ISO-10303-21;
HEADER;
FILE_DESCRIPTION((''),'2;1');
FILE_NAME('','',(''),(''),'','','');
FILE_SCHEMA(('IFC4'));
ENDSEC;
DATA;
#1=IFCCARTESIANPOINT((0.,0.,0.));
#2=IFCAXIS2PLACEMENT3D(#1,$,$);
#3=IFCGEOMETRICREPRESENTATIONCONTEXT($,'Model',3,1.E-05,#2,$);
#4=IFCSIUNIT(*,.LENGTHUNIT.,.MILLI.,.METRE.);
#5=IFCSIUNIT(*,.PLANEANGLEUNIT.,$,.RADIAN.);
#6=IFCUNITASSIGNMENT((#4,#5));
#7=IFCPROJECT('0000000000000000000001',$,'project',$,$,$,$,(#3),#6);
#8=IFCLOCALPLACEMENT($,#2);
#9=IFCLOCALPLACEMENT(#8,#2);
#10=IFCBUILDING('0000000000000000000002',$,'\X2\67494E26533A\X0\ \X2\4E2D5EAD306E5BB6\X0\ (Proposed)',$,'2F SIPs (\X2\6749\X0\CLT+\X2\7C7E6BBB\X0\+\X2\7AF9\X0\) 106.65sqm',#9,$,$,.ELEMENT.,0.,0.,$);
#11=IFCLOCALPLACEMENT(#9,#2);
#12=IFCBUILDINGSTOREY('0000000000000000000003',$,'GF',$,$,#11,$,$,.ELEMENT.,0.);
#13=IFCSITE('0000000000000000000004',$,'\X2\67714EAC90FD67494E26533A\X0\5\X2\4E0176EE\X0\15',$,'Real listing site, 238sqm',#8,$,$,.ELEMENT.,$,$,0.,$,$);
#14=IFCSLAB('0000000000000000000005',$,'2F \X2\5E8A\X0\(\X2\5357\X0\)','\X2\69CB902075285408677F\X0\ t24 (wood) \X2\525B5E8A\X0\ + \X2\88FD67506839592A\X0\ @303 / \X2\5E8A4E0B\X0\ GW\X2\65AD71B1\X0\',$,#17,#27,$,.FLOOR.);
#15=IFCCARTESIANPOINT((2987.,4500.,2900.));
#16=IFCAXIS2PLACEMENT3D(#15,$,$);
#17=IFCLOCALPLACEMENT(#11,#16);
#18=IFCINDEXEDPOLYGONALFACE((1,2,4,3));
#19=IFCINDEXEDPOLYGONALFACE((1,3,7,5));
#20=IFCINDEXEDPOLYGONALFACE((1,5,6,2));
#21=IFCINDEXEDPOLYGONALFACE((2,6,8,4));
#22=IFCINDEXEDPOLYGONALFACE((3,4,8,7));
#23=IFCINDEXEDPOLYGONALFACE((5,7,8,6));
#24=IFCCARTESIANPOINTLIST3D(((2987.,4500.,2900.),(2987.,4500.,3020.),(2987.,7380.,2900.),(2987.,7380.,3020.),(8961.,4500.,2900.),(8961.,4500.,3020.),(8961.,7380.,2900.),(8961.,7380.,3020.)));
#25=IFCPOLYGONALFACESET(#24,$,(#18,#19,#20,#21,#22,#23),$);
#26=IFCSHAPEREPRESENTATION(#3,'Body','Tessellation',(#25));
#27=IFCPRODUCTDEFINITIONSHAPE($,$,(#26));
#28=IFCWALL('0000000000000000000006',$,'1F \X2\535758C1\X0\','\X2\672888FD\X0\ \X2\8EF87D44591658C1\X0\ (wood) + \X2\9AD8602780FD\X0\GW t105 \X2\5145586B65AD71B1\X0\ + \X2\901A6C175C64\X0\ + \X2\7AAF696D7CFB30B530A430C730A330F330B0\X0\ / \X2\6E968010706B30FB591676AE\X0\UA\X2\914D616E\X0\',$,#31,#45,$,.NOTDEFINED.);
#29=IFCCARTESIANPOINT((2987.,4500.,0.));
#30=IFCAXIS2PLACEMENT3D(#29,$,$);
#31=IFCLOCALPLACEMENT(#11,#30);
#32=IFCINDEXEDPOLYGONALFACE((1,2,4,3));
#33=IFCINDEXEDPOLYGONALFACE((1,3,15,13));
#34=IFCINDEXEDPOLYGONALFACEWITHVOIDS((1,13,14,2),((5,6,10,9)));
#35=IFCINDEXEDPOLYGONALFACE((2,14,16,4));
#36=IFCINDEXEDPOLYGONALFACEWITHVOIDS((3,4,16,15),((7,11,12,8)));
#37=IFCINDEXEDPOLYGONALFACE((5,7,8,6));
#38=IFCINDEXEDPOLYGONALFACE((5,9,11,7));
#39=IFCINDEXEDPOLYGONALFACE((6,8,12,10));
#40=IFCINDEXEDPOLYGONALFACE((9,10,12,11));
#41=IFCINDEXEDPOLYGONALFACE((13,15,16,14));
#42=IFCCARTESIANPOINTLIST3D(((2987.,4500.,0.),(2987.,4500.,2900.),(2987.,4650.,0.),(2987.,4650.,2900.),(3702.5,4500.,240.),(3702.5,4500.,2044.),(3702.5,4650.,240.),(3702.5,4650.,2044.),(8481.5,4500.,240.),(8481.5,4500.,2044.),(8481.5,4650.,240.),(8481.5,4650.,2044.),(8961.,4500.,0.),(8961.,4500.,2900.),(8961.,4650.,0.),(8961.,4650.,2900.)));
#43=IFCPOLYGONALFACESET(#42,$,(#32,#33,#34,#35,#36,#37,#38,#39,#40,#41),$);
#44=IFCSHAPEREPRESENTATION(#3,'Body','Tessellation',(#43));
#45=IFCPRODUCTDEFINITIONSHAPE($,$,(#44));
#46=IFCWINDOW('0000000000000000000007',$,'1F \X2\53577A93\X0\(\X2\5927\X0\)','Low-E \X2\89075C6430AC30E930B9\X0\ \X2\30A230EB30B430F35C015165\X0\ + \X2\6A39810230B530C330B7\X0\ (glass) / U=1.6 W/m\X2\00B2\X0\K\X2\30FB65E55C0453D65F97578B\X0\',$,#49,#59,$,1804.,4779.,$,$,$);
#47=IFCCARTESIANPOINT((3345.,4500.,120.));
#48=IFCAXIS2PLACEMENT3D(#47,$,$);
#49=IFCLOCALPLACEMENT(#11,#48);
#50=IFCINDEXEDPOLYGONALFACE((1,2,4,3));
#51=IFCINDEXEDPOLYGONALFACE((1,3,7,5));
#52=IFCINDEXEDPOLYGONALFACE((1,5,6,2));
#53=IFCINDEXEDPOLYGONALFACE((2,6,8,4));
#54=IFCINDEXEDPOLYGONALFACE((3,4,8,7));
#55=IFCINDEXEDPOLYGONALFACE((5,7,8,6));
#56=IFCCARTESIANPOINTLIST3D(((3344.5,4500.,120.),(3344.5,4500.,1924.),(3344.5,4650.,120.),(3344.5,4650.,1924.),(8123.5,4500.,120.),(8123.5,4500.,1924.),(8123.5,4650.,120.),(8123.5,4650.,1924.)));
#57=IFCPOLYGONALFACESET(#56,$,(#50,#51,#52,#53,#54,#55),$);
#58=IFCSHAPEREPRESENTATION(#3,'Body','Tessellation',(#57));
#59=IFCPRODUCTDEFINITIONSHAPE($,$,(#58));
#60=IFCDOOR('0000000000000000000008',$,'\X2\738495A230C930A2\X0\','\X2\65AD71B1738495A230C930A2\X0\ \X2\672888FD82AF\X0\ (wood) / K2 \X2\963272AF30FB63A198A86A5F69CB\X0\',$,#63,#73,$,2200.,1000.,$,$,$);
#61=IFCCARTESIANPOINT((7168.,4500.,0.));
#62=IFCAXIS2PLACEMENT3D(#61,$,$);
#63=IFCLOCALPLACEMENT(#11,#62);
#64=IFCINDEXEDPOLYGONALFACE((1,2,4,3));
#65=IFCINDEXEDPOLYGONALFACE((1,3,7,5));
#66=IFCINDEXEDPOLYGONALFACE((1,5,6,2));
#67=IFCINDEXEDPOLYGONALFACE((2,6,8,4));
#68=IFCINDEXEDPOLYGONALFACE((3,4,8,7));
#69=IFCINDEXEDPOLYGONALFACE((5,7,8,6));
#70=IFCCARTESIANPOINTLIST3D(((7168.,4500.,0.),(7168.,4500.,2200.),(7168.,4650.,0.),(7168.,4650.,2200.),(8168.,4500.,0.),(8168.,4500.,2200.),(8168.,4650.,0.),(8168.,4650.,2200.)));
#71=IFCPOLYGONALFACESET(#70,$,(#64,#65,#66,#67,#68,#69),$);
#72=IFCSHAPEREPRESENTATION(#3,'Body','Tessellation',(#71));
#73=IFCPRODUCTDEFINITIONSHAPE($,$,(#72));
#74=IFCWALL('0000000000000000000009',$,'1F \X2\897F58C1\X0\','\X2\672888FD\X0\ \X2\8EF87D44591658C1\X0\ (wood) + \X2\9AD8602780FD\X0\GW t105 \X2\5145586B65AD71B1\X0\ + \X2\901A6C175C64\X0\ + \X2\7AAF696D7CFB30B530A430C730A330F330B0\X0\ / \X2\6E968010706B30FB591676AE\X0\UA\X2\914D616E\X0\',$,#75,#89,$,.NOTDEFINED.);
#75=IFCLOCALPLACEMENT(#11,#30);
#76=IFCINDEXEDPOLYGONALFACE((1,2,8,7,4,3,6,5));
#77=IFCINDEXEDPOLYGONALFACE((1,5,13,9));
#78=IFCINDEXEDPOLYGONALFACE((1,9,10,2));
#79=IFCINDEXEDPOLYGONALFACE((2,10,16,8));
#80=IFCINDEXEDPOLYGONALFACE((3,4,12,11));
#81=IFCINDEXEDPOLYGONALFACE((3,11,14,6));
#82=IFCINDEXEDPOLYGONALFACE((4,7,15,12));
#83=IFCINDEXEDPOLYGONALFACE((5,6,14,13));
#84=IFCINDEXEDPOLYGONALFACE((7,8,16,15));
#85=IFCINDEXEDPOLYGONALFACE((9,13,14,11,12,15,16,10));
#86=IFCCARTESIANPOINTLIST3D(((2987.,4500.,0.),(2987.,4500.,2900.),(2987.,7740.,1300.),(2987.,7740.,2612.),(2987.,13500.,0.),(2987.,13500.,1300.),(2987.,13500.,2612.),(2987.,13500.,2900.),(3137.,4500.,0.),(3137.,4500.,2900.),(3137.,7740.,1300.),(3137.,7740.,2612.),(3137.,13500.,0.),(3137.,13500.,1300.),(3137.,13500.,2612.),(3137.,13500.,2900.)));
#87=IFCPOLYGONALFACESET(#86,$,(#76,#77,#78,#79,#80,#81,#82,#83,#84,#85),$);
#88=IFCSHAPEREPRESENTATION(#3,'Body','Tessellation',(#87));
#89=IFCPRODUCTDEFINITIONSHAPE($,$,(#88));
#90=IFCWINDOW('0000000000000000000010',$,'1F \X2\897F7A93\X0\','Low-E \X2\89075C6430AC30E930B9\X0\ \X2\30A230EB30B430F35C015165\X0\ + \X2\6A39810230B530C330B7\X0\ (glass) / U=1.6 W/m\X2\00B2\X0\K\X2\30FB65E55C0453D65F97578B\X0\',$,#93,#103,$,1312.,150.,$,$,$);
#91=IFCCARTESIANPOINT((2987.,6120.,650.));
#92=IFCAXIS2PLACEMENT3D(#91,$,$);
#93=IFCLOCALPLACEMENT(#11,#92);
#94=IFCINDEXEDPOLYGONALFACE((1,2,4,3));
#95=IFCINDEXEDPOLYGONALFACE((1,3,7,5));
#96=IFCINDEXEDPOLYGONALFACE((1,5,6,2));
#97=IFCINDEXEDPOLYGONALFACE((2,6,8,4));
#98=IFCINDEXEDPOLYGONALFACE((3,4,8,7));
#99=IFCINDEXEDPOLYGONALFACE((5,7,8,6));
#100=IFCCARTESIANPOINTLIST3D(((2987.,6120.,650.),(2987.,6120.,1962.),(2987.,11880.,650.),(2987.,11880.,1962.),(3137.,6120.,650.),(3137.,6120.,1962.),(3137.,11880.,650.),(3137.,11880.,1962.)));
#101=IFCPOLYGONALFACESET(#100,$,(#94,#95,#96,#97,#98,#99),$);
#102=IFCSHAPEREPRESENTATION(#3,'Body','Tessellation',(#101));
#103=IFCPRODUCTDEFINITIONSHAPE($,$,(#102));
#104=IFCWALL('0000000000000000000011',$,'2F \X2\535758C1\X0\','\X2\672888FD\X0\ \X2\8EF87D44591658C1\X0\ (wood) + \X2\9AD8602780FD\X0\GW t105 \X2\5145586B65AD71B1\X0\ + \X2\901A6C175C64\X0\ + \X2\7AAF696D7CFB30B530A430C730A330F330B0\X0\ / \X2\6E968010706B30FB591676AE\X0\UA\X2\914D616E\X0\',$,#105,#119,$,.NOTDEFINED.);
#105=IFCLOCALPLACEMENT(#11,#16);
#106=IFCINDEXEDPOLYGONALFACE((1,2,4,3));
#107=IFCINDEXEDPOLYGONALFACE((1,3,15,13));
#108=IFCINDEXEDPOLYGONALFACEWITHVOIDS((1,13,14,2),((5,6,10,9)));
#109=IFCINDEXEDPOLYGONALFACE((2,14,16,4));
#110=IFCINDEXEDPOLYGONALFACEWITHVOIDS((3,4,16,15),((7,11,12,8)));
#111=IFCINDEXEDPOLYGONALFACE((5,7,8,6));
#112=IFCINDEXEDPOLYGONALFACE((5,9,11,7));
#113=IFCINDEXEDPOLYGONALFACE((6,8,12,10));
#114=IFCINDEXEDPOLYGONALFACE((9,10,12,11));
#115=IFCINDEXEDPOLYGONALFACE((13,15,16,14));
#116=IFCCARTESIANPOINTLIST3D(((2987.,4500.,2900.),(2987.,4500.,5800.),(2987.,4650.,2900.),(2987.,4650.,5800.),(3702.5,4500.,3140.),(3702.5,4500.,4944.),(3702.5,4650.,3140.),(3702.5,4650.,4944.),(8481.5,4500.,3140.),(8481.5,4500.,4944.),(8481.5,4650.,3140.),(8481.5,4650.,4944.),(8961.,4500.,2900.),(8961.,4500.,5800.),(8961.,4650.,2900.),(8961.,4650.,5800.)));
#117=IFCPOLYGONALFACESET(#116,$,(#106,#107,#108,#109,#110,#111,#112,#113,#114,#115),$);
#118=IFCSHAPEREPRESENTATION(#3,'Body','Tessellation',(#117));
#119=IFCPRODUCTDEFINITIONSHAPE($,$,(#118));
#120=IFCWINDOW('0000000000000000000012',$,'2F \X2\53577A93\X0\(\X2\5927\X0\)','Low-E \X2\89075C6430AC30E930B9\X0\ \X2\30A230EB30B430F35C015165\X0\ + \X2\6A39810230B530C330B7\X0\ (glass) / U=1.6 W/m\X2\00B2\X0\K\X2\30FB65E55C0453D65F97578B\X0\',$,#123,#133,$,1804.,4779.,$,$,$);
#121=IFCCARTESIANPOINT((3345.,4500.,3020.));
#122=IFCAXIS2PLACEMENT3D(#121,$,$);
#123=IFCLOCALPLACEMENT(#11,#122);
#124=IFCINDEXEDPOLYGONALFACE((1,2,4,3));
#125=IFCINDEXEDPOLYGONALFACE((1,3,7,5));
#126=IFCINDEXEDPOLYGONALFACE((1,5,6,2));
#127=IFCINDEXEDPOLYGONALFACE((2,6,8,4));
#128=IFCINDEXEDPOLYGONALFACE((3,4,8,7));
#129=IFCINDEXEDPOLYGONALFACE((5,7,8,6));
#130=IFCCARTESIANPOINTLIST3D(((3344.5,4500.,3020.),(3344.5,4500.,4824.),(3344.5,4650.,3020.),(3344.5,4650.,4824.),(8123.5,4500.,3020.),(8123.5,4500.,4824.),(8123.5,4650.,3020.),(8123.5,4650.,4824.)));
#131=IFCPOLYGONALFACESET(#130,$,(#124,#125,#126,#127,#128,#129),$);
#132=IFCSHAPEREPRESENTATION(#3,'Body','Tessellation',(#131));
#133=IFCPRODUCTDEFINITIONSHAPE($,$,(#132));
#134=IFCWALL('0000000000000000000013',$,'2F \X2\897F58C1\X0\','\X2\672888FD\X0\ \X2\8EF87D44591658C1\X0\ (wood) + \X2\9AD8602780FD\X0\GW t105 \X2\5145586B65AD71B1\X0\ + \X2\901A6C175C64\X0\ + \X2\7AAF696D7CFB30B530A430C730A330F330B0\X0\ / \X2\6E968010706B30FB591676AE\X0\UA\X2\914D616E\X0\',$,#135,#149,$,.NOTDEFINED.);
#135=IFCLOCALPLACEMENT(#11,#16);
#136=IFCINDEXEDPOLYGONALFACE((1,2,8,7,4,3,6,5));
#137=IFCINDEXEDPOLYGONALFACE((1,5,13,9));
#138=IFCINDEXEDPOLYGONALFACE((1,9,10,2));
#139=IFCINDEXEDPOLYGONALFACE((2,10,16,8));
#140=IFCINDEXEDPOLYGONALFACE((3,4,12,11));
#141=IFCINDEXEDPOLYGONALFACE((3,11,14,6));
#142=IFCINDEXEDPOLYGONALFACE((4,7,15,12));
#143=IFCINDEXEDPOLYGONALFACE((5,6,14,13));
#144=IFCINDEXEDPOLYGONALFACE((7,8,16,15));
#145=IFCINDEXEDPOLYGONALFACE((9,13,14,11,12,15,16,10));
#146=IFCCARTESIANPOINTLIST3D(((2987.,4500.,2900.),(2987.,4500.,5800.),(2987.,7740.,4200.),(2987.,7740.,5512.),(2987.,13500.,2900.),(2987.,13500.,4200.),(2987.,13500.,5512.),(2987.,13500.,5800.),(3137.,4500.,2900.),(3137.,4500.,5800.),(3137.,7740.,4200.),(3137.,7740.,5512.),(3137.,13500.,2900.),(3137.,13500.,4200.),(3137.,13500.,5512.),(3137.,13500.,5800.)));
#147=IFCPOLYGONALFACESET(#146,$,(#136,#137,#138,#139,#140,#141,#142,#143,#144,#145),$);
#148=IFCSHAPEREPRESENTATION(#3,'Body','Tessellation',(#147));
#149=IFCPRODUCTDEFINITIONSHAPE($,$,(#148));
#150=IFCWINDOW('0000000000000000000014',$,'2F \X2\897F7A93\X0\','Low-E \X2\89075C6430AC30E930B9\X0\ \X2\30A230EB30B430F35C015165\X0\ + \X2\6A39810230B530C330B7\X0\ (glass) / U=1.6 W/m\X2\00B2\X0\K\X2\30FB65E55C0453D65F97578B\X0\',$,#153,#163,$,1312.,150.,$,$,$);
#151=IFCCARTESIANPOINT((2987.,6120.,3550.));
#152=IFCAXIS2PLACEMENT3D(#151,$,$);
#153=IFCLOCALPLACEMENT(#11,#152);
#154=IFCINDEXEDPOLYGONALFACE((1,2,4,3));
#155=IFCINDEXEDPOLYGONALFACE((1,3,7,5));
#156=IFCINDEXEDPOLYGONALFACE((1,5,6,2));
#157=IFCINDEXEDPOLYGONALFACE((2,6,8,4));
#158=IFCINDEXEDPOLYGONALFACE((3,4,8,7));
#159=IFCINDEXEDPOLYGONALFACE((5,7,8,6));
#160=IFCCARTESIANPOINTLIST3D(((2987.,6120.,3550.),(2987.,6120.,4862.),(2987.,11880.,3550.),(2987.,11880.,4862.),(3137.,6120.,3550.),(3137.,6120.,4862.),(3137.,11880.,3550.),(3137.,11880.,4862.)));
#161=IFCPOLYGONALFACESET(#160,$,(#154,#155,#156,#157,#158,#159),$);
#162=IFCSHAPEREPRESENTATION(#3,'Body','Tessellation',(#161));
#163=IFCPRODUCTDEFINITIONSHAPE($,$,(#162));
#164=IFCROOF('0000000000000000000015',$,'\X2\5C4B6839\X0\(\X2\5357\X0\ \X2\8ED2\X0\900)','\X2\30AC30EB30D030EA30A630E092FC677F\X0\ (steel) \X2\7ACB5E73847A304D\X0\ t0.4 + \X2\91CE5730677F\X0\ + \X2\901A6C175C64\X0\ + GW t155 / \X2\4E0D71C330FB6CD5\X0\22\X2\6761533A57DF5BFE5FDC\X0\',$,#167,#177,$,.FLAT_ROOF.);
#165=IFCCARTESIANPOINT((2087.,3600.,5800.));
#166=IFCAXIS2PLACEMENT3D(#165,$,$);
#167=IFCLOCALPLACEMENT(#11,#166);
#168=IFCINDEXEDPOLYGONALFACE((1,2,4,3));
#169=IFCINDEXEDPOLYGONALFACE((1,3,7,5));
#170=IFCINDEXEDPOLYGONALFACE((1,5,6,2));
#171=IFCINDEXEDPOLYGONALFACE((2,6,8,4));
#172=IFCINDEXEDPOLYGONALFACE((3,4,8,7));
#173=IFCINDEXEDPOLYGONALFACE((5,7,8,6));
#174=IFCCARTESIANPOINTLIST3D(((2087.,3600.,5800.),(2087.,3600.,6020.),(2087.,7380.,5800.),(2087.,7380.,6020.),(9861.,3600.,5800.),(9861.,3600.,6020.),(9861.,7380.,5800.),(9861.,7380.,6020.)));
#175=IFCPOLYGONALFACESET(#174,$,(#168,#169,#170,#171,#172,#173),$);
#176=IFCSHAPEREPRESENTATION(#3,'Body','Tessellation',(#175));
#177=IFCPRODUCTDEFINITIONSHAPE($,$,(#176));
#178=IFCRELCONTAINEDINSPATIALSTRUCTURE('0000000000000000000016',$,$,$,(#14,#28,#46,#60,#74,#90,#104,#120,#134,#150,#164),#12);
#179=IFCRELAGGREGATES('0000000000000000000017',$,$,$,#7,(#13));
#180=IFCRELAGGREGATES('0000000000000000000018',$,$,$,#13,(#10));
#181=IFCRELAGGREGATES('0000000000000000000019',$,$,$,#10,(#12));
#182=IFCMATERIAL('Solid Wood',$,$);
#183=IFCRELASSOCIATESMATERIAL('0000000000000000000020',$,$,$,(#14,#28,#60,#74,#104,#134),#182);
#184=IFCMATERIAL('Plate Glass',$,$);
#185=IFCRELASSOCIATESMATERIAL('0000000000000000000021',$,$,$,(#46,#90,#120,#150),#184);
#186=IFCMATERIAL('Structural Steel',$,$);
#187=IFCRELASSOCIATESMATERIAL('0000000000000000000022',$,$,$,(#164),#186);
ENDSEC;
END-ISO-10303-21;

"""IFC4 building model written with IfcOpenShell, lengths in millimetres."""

from ifc_helpers import new_model, si_unit, frame, frame_2d, origin, place, context, project, spatial, rectangle, extrude, material, element, fill, save


model = new_model("IFC4")

# Units and contexts
model_context = context("Model", 3, precision=1e-05, world=origin())
ifc_project = project(units=[si_unit("LENGTHUNIT", "METRE", prefix="MILLI"), si_unit("PLANEANGLEUNIT", "RADIAN")], contexts=[model_context])

# Site, building, storey
site_placement = place(None, origin())
site = spatial("IfcSite", under=ifc_project, at=site_placement, Name="東京都杉並区5丁目15", ObjectType="Real listing site, 238sqm", CompositionType="ELEMENT", RefElevation=0.0)
building_placement = place(site_placement, origin())
building = spatial("IfcBuilding", under=site, at=building_placement, Name="杉並区 中庭の家 (Proposed)", ObjectType="2F SIPs (杉CLT+籾殻+竹) 106.65sqm", CompositionType="ELEMENT", ElevationOfRefHeight=0.0, ElevationOfTerrain=0.0)
storey_placement = place(building_placement, origin())
storey = spatial("IfcBuildingStorey", under=building, at=storey_placement, Name="GF", CompositionType="ELEMENT", Elevation=0.0)

# Slab
ifc_material_1 = material(Name="Solid Wood")
slab_1_placement = place(storey_placement, frame((2987.0, 4500.0, 2900.0)))
element("IfcSlab", 1, at=slab_1_placement, inside=storey, material=ifc_material_1, Name="2F 床(南)", Description="構造用合板 t24 (wood) 剛床 + 製材根太 @303 / 床下 GW断熱", PredefinedType="FLOOR", context=model_context, shape_type="SweptSolid", body=[
    extrude(rectangle(XDim=5974.0, YDim=2880.0, at=frame_2d((2987.0, 1440.0))), frame((2987.0, 4500.0, 2900.0)), (0.0, 0.0, 1.0), 120.0),
])

# Wall, openings, window, door
wall_1_placement = place(storey_placement, frame((2987.0, 4500.0, 0.0)))
wall_1 = element("IfcWall", 2, at=wall_1_placement, inside=storey, material=ifc_material_1, Name="1F 南壁", Description="木製 軸組外壁 (wood) + 高性能GW t105 充填断熱 + 通気層 + 窯業系サイディング / 準耐火・外皮UA配慮", PredefinedType="NOTDEFINED", context=model_context, shape_type="SweptSolid", body=[
    extrude(rectangle(XDim=5974.0, YDim=150.0, at=frame_2d((2987.0, 75.0))), frame((2987.0, 4500.0, 0.0)), (0.0, 0.0, 1.0), 2900.0),
])
opening_1_placement = place(storey_placement, frame((3345.0, 4500.0, 120.0)))
opening_1 = element("IfcOpeningElement", 3, at=opening_1_placement, cuts=wall_1, PredefinedType="NOTDEFINED", context=model_context, shape_type="SweptSolid", body=[
    extrude(rectangle(XDim=4779.0, YDim=150.0, at=frame_2d((2389.0, 75.0))), frame((3345.0, 4500.0, 120.0)), (0.0, 0.0, 1.0), 1804.0),
])
opening_2_placement = place(storey_placement, frame((7168.0, 4500.0, 0.0)))
opening_2 = element("IfcOpeningElement", 4, at=opening_2_placement, cuts=wall_1, PredefinedType="NOTDEFINED", context=model_context, shape_type="SweptSolid", body=[
    extrude(rectangle(XDim=1000.0, YDim=150.0, at=frame_2d((500.0, 75.0))), frame((7168.0, 4500.0, 0.0)), (0.0, 0.0, 1.0), 2200.0),
])
ifc_material_2 = material(Name="Plate Glass")
window_1_placement = place(storey_placement, frame((3345.0, 4500.0, 120.0)))
window_1 = element("IfcWindow", 5, at=window_1_placement, inside=storey, material=ifc_material_2, Name="1F 南窓(大)", Description="Low-E 複層ガラス アルゴン封入 + 樹脂サッシ (glass) / U=1.6 W/m²K・日射取得型", OverallHeight=1804.0, OverallWidth=4779.0, context=model_context, shape_type="SweptSolid", body=[
    extrude(rectangle(XDim=4779.0, YDim=150.0, at=frame_2d((2389.0, 75.0))), frame((3345.0, 4500.0, 120.0)), (0.0, 0.0, 1.0), 1804.0),
])
fill(opening_1, window_1)
door_placement = place(storey_placement, frame((7168.0, 4500.0, 0.0)))
door = element("IfcDoor", 6, at=door_placement, inside=storey, material=ifc_material_1, Name="玄関ドア", Description="断熱玄関ドア 木製芯 (wood) / K2 防犯・採風機構", OverallHeight=2200.0, OverallWidth=1000.0, context=model_context, shape_type="SweptSolid", body=[
    extrude(rectangle(XDim=1000.0, YDim=150.0, at=frame_2d((500.0, 75.0))), frame((7168.0, 4500.0, 0.0)), (0.0, 0.0, 1.0), 2200.0),
])
fill(opening_2, door)

# Walls, openings, windows
wall_2_placement = place(storey_placement, frame((2987.0, 4500.0, 0.0)))
wall_2 = element("IfcWall", 7, at=wall_2_placement, inside=storey, material=ifc_material_1, Name="1F 西壁", Description="木製 軸組外壁 (wood) + 高性能GW t105 充填断熱 + 通気層 + 窯業系サイディング / 準耐火・外皮UA配慮", PredefinedType="NOTDEFINED", context=model_context, shape_type="SweptSolid", body=[
    extrude(rectangle(XDim=150.0, YDim=9000.0, at=frame_2d((75.0, 4500.0))), frame((2987.0, 4500.0, 0.0)), (0.0, 0.0, 1.0), 2900.0),
])
opening_3_placement = place(storey_placement, frame((2987.0, 6120.0, 650.0)))
opening_3 = element("IfcOpeningElement", 8, at=opening_3_placement, cuts=wall_2, PredefinedType="NOTDEFINED", context=model_context, shape_type="SweptSolid", body=[
    extrude(rectangle(XDim=150.0, YDim=5760.0, at=frame_2d((75.0, 2880.0))), frame((2987.0, 6120.0, 650.0)), (0.0, 0.0, 1.0), 1312.0),
])
window_2_placement = place(storey_placement, frame((2987.0, 6120.0, 650.0)))
window_2 = element("IfcWindow", 9, at=window_2_placement, inside=storey, material=ifc_material_2, Name="1F 西窓", Description="Low-E 複層ガラス アルゴン封入 + 樹脂サッシ (glass) / U=1.6 W/m²K・日射取得型", OverallHeight=1312.0, OverallWidth=150.0, context=model_context, shape_type="SweptSolid", body=[
    extrude(rectangle(XDim=150.0, YDim=5760.0, at=frame_2d((75.0, 2880.0))), frame((2987.0, 6120.0, 650.0)), (0.0, 0.0, 1.0), 1312.0),
])
fill(opening_3, window_2)
wall_3_placement = place(storey_placement, frame((2987.0, 4500.0, 2900.0)))
wall_3 = element("IfcWall", 10, at=wall_3_placement, inside=storey, material=ifc_material_1, Name="2F 南壁", Description="木製 軸組外壁 (wood) + 高性能GW t105 充填断熱 + 通気層 + 窯業系サイディング / 準耐火・外皮UA配慮", PredefinedType="NOTDEFINED", context=model_context, shape_type="SweptSolid", body=[
    extrude(rectangle(XDim=5974.0, YDim=150.0, at=frame_2d((2987.0, 75.0))), frame((2987.0, 4500.0, 2900.0)), (0.0, 0.0, 1.0), 2900.0),
])
opening_4_placement = place(storey_placement, frame((3345.0, 4500.0, 3020.0)))
opening_4 = element("IfcOpeningElement", 11, at=opening_4_placement, cuts=wall_3, PredefinedType="NOTDEFINED", context=model_context, shape_type="SweptSolid", body=[
    extrude(rectangle(XDim=4779.0, YDim=150.0, at=frame_2d((2389.0, 75.0))), frame((3345.0, 4500.0, 3020.0)), (0.0, 0.0, 1.0), 1804.0),
])
window_3_placement = place(storey_placement, frame((3345.0, 4500.0, 3020.0)))
window_3 = element("IfcWindow", 12, at=window_3_placement, inside=storey, material=ifc_material_2, Name="2F 南窓(大)", Description="Low-E 複層ガラス アルゴン封入 + 樹脂サッシ (glass) / U=1.6 W/m²K・日射取得型", OverallHeight=1804.0, OverallWidth=4779.0, context=model_context, shape_type="SweptSolid", body=[
    extrude(rectangle(XDim=4779.0, YDim=150.0, at=frame_2d((2389.0, 75.0))), frame((3345.0, 4500.0, 3020.0)), (0.0, 0.0, 1.0), 1804.0),
])
fill(opening_4, window_3)
wall_4_placement = place(storey_placement, frame((2987.0, 4500.0, 2900.0)))
wall_4 = element("IfcWall", 13, at=wall_4_placement, inside=storey, material=ifc_material_1, Name="2F 西壁", Description="木製 軸組外壁 (wood) + 高性能GW t105 充填断熱 + 通気層 + 窯業系サイディング / 準耐火・外皮UA配慮", PredefinedType="NOTDEFINED", context=model_context, shape_type="SweptSolid", body=[
    extrude(rectangle(XDim=150.0, YDim=9000.0, at=frame_2d((75.0, 4500.0))), frame((2987.0, 4500.0, 2900.0)), (0.0, 0.0, 1.0), 2900.0),
])
opening_5_placement = place(storey_placement, frame((2987.0, 6120.0, 3550.0)))
opening_5 = element("IfcOpeningElement", 14, at=opening_5_placement, cuts=wall_4, PredefinedType="NOTDEFINED", context=model_context, shape_type="SweptSolid", body=[
    extrude(rectangle(XDim=150.0, YDim=5760.0, at=frame_2d((75.0, 2880.0))), frame((2987.0, 6120.0, 3550.0)), (0.0, 0.0, 1.0), 1312.0),
])
window_4_placement = place(storey_placement, frame((2987.0, 6120.0, 3550.0)))
window_4 = element("IfcWindow", 15, at=window_4_placement, inside=storey, material=ifc_material_2, Name="2F 西窓", Description="Low-E 複層ガラス アルゴン封入 + 樹脂サッシ (glass) / U=1.6 W/m²K・日射取得型", OverallHeight=1312.0, OverallWidth=150.0, context=model_context, shape_type="SweptSolid", body=[
    extrude(rectangle(XDim=150.0, YDim=5760.0, at=frame_2d((75.0, 2880.0))), frame((2987.0, 6120.0, 3550.0)), (0.0, 0.0, 1.0), 1312.0),
])
fill(opening_5, window_4)

# Roof
ifc_material_3 = material(Name="Structural Steel")
roof_1_placement = place(storey_placement, frame((2087.0, 3600.0, 5800.0)))
element("IfcRoof", 16, at=roof_1_placement, inside=storey, material=ifc_material_3, Name="屋根(南 軒900)", Description="ガルバリウム鋼板 (steel) 立平葺き t0.4 + 野地板 + 通気層 + GW t155 / 不燃・法22条区域対応", PredefinedType="FLAT_ROOF", context=model_context, shape_type="SweptSolid", body=[
    extrude(rectangle(XDim=7774.0, YDim=3780.0, at=frame_2d((3887.0, 1890.0))), frame((2087.0, 3600.0, 5800.0)), (0.0, 0.0, 1.0), 220.0),
])

save(model, "model.ifc")
